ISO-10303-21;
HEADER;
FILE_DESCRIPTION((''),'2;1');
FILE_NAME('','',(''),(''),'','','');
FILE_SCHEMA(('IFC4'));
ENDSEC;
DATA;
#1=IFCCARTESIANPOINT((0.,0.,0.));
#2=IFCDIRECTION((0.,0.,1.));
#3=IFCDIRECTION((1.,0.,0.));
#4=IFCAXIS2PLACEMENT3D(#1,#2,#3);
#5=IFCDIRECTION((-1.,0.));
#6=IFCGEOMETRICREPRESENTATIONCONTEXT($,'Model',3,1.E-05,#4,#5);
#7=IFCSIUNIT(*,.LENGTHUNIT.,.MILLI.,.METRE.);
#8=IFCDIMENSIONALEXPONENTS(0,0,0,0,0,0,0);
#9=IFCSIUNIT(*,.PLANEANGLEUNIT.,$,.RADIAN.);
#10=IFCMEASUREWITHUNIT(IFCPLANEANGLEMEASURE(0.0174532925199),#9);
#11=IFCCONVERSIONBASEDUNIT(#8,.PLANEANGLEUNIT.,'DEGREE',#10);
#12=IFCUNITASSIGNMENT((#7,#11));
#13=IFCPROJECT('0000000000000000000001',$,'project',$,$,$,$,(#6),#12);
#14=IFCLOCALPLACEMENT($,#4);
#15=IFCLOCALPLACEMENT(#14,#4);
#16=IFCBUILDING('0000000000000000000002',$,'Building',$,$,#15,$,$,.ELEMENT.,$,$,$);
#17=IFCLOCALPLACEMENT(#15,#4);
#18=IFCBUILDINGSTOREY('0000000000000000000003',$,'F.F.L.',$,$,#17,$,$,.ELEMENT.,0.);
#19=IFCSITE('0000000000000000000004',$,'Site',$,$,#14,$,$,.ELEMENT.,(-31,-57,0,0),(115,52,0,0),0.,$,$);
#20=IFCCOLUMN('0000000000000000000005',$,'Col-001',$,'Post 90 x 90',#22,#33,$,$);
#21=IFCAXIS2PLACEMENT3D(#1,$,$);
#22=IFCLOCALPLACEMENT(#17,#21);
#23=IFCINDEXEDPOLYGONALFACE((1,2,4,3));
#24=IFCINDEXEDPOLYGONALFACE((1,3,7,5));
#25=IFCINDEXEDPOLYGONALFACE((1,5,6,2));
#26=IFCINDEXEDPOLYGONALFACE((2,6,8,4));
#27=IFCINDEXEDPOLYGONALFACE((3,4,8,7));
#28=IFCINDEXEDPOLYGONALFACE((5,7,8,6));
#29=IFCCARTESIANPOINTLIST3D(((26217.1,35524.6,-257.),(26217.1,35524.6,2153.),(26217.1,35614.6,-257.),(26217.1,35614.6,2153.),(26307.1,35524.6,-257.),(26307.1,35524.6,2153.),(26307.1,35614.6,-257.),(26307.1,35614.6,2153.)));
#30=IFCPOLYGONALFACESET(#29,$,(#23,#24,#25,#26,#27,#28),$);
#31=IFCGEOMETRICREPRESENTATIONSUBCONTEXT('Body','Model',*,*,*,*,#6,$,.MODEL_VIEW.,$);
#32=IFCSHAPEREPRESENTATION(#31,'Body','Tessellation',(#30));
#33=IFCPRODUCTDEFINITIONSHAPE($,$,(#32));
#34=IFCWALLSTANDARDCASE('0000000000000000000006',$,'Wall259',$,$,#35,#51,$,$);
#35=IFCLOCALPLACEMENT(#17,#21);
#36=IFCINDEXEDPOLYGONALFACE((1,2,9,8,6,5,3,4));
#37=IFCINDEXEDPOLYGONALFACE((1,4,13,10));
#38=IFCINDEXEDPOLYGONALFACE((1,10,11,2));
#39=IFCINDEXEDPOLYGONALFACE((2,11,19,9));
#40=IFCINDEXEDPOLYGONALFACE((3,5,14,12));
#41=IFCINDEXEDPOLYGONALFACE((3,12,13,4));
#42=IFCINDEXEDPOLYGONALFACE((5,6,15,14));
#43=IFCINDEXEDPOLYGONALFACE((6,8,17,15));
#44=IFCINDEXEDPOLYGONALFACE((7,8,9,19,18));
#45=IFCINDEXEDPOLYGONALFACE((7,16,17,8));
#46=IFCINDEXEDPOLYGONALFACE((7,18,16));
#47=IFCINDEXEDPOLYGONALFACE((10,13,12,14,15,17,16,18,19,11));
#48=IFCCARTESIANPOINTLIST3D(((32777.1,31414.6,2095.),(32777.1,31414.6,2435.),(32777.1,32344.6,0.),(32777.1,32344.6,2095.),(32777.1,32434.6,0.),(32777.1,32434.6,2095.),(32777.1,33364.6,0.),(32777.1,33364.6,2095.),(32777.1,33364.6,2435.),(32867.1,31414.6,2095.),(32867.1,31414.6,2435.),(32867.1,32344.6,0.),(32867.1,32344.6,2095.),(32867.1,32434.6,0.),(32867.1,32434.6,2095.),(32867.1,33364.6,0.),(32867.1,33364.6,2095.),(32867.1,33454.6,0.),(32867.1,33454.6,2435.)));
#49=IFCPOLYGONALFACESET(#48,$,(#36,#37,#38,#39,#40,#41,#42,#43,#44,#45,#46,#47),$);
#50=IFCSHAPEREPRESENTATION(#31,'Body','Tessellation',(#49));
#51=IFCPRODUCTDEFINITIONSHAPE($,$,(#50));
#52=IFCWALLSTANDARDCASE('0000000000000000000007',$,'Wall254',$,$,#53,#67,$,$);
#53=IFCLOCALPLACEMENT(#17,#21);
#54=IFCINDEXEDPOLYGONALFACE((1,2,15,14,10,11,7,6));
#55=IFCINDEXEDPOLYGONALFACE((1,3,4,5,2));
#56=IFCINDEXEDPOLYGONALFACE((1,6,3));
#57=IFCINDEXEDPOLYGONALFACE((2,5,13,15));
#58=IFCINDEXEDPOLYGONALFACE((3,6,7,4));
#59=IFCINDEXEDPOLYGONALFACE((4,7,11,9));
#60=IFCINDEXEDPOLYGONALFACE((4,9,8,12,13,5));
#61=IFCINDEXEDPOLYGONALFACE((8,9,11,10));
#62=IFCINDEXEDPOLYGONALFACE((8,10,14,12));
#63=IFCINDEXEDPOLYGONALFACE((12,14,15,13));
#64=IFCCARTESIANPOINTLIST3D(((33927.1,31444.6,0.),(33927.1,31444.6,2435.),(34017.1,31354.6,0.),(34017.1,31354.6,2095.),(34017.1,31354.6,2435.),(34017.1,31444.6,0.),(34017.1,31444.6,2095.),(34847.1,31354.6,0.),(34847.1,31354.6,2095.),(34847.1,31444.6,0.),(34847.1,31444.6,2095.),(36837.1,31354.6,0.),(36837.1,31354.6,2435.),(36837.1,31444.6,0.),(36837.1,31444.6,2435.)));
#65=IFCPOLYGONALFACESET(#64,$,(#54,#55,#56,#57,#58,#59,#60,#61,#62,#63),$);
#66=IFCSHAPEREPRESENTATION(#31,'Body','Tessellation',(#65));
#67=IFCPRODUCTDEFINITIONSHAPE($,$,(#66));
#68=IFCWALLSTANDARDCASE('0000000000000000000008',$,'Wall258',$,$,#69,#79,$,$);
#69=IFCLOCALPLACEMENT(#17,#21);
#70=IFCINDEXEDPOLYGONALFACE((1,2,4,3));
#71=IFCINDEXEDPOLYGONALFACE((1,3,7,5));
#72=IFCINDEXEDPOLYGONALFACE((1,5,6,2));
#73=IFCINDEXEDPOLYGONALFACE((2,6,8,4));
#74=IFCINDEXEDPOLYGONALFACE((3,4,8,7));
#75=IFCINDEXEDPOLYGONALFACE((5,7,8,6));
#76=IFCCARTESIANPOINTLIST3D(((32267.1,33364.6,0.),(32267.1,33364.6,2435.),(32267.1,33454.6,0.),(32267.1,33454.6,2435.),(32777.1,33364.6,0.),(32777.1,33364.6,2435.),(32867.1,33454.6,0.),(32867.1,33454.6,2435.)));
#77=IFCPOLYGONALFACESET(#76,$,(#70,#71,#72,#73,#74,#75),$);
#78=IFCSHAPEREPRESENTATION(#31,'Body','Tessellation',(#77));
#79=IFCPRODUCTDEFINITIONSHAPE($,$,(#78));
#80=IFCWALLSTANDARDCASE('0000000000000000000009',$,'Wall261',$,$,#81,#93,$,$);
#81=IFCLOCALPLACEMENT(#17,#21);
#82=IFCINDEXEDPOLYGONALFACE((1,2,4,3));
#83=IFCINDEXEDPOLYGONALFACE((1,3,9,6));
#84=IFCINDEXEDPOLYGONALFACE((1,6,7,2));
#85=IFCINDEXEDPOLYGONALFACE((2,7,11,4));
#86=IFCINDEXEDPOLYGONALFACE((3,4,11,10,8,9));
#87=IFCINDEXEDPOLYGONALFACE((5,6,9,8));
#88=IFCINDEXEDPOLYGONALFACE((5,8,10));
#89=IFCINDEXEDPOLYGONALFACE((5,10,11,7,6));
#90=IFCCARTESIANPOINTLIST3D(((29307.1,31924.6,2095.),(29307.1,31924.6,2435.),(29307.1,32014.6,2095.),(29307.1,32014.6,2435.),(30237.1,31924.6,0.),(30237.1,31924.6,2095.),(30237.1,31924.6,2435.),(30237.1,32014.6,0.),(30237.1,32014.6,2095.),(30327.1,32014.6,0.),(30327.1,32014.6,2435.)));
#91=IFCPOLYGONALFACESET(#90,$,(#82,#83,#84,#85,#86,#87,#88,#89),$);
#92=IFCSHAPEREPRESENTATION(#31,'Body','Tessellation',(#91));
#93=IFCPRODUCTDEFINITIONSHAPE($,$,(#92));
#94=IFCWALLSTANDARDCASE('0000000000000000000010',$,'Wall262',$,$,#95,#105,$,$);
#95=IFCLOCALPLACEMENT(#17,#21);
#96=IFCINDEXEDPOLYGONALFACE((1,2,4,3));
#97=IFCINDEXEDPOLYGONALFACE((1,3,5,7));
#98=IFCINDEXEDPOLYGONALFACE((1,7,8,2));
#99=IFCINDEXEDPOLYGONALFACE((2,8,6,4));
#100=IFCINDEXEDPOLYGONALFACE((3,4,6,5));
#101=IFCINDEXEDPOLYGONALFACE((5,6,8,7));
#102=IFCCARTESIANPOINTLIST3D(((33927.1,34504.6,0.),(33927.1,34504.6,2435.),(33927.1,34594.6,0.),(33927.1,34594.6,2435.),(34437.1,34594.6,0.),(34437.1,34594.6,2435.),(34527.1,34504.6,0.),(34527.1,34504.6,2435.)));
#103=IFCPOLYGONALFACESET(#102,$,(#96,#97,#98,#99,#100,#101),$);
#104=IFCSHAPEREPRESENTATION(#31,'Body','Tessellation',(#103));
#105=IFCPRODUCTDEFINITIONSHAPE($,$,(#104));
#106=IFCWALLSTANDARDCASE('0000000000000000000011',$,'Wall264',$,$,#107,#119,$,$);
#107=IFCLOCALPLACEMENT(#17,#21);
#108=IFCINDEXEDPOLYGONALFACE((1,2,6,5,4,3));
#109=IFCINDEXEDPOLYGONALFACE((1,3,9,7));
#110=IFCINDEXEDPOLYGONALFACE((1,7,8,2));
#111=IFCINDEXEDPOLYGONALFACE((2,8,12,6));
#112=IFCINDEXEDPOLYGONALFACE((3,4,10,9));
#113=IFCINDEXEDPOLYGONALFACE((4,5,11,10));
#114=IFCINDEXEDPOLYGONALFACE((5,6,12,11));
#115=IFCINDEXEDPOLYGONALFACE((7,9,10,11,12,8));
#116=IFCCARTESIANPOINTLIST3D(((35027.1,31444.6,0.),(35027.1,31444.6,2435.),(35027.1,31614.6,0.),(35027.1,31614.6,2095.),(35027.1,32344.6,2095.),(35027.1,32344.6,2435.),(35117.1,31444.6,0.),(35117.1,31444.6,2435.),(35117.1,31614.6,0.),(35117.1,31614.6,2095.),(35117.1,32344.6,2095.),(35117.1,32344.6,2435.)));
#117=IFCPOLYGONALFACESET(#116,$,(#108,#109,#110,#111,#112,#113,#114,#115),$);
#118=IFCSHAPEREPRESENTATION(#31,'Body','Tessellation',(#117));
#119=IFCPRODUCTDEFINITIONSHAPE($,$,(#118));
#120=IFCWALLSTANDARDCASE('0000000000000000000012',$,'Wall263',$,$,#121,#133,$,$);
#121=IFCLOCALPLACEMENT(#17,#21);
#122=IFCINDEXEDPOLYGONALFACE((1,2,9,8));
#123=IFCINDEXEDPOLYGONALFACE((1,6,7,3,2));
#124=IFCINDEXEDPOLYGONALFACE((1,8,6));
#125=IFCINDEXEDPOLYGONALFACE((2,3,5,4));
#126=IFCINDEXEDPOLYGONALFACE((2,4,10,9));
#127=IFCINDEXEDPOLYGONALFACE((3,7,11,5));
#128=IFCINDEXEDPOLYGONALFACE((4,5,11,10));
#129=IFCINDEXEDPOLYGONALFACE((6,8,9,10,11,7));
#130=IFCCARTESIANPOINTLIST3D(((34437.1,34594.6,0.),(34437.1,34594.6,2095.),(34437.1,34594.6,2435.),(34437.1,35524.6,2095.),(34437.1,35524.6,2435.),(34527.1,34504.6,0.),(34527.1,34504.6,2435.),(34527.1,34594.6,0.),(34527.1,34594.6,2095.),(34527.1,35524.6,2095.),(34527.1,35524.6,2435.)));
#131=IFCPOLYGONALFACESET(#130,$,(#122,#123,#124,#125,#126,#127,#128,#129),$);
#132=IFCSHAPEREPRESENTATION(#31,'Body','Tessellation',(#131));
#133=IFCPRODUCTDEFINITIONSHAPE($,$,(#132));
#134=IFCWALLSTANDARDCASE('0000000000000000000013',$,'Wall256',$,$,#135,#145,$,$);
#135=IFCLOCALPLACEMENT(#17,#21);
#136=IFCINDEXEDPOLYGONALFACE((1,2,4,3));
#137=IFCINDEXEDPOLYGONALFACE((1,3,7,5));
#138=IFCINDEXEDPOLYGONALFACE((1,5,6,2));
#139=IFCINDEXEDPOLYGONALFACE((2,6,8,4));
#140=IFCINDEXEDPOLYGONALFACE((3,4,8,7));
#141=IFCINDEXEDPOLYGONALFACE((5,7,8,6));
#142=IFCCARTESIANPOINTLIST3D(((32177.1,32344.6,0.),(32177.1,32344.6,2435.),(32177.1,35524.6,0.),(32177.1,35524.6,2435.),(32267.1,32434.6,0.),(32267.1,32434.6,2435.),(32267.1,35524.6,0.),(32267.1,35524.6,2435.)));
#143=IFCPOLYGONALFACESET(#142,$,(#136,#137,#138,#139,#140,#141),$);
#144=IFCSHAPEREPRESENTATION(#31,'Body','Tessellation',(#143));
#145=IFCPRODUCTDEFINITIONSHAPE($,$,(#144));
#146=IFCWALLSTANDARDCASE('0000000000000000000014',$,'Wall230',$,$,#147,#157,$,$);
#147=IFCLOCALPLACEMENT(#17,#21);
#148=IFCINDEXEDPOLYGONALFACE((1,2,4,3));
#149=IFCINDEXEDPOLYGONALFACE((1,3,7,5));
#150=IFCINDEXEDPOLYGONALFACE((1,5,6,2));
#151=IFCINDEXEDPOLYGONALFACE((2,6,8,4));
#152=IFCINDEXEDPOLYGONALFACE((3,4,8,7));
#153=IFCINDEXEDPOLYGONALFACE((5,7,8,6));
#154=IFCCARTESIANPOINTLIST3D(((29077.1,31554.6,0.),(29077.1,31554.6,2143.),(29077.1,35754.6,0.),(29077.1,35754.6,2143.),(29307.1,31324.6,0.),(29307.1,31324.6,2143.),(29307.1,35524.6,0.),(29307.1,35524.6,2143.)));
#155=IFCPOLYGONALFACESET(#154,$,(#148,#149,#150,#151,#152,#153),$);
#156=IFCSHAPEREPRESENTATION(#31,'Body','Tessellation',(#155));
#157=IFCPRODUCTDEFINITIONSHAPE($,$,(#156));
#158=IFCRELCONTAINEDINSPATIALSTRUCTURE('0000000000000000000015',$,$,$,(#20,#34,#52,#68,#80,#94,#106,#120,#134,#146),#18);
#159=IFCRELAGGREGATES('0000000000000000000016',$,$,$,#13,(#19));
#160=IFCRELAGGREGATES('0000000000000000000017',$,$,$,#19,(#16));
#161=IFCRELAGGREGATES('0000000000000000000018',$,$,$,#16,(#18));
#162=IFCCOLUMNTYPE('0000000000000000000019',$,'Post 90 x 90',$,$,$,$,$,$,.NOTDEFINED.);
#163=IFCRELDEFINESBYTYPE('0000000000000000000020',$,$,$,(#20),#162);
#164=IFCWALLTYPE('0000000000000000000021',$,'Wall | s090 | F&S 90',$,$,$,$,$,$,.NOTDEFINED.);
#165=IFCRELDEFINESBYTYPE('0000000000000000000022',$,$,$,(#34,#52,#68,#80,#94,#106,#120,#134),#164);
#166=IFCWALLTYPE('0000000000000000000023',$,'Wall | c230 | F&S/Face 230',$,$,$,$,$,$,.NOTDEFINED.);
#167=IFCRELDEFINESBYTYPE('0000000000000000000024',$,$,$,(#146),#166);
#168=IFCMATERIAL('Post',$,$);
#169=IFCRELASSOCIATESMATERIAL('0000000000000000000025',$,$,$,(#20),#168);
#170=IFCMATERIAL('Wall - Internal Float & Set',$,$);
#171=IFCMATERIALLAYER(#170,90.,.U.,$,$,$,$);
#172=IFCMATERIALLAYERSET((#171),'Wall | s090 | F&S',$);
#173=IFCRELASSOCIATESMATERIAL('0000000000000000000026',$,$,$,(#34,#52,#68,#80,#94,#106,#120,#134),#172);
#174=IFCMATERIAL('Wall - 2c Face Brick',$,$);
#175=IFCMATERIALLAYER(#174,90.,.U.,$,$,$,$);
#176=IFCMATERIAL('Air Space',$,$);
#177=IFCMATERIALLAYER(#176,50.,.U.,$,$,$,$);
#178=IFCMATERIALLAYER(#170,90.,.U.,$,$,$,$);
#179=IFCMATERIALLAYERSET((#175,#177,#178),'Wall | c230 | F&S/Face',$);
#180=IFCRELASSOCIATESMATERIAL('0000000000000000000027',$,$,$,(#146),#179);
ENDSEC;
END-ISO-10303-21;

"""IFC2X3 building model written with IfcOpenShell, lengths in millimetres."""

from ifc_helpers import new_model, entity, si_unit, converted_unit, direction, frame, origin_with_axes, origin_2d_with_axis, place, context, subcontext, project, spatial, polyline, rectangle, outline, extrude, material, layer, layer_set, layer_usage, type_object, element, save


model = new_model("IFC2X3")

# Units and contexts
model_context = context("Model", 3, precision=1e-05, world=origin_with_axes(), true_north=direction((-1.0, 0.0)))
body_context = subcontext(model_context, "Body", "Model", "MODEL_VIEW")
ifc_project = project(units=[si_unit("LENGTHUNIT", "METRE", prefix="MILLI"), converted_unit("PLANEANGLEUNIT", "DEGREE", entity("IfcPlaneAngleMeasure", 0.0174532925199), si_unit("PLANEANGLEUNIT", "RADIAN"), dimensions=[0, 0, 0, 0, 0, 0, 0])], contexts=[model_context])

# Site, building, storey
site_placement = place(None, origin_with_axes())
site = spatial("IfcSite", under=ifc_project, at=site_placement, Name="Site", CompositionType="ELEMENT", RefLatitude=(-31, -57, 0, 0), RefLongitude=(115, 52, 0, 0), RefElevation=0.0)
building_placement = place(site_placement, origin_with_axes())
building = spatial("IfcBuilding", under=site, at=building_placement, Name="Building", CompositionType="ELEMENT")
storey_placement = place(building_placement, origin_with_axes())
storey = spatial("IfcBuildingStorey", under=building, at=storey_placement, Name="F.F.L.", CompositionType="ELEMENT", Elevation=0.0)

# Column
ifc_material_1 = material(Name="Post")
column_type = type_object("IfcColumnType", Name="Post 90 x 90", PredefinedType="NOTDEFINED")
column_placement = place(storey_placement, frame((26262.1, 35569.6, -257.0), z_axis=(0.0, 0.0, 1.0), x_axis=(1.0, 0.0, 0.0)))
element("IfcColumn", 1, at=column_placement, inside=storey, type_object=column_type, material=ifc_material_1, Name="Col-001", ObjectType="Post 90 x 90", context=body_context, shape_type="SweptSolid", body=[
    extrude(rectangle(XDim=90.0, YDim=90.0, at=origin_2d_with_axis()), origin_with_axes(), (0.0, 0.0, 1.0), 2410.0),
])

# Shared definitions
ifc_material_2 = material(Name="Wall - Internal Float & Set")
ifc_layer_1 = layer(ifc_material_2, 90.0, ventilated="UNKNOWN")
ifc_layer_set_1 = layer_set([ifc_layer_1], Name="Wall | s090 | F&S")
wall_type_1 = type_object("IfcWallType", Name="Wall | s090 | F&S 90", PredefinedType="NOTDEFINED")

# Wall, openings
ifc_layer_usage_1 = layer_usage(ifc_layer_set_1, "AXIS2", "POSITIVE", -90.0)
wall_1_placement = place(storey_placement, frame((32867.1, 33454.6, 0.0), z_axis=(0.0, 0.0, 1.0), x_axis=(0.0, -1.0, 0.0)))
wall_1 = element("IfcWallStandardCase", 2, at=wall_1_placement, inside=storey, type_object=wall_type_1, material=ifc_layer_usage_1, Name="Wall259", context=body_context, shape_type="SweptSolid", body=[
    extrude(outline(polyline([(90.0, -90.0), (2040.0, -90.0), (2040.0, 0.0), (0.0, 0.0), (90.0, -90.0)])), origin_with_axes(), (0.0, 0.0, 1.0), 2435.0),
])
opening_1_placement = place(wall_1_placement, frame((555.0, 0.0, 0.0), z_axis=(0.0, 0.0, 1.0), x_axis=(1.0, 0.0, 0.0)))
element("IfcOpeningElement", 3, at=opening_1_placement, cuts=wall_1, context=body_context, shape_type="SweptSolid", body=[
    extrude(rectangle(XDim=930.0, YDim=2095.0, at=origin_2d_with_axis()), frame((0.0, -90.0, 1047.5), z_axis=(0.0, 1.0, 0.0), x_axis=(1.0, 0.0, 0.0)), (0.0, 0.0, 1.0), 180.0),
])
opening_2_placement = place(wall_1_placement, frame((1575.0, 0.0, 0.0), z_axis=(0.0, 0.0, 1.0), x_axis=(1.0, 0.0, 0.0)))
element("IfcOpeningElement", 4, at=opening_2_placement, cuts=wall_1, context=body_context, shape_type="SweptSolid", body=[
    extrude(rectangle(XDim=930.0, YDim=2095.0, at=origin_2d_with_axis()), frame((0.0, 90.0, 1047.5), z_axis=(0.0, 1.0, 0.0), x_axis=(1.0, 0.0, 0.0)), (0.0, 0.0, -1.0), 180.0),
])

# Wall, opening
ifc_layer_usage_2 = layer_usage(ifc_layer_set_1, "AXIS2", "POSITIVE", -90.0)
wall_2_placement = place(storey_placement, frame((33927.1, 31444.6, 0.0), z_axis=(0.0, 0.0, 1.0), x_axis=(1.0, 0.0, 0.0)))
wall_2 = element("IfcWallStandardCase", 5, at=wall_2_placement, inside=storey, type_object=wall_type_1, material=ifc_layer_usage_2, Name="Wall254", context=body_context, shape_type="SweptSolid", body=[
    extrude(outline(polyline([(90.0, -90.0), (2910.0, -90.0), (2910.0, 0.0), (0.0, 0.0), (90.0, -90.0)])), origin_with_axes(), (0.0, 0.0, 1.0), 2435.0),
])
opening_3_placement = place(wall_2_placement, frame((505.0, 0.0, 0.0), z_axis=(0.0, 0.0, 1.0), x_axis=(1.0, 0.0, 0.0)))
element("IfcOpeningElement", 6, at=opening_3_placement, cuts=wall_2, context=body_context, shape_type="SweptSolid", body=[
    extrude(rectangle(XDim=830.0, YDim=2095.0, at=origin_2d_with_axis()), frame((0.0, 90.0, 1047.5), z_axis=(0.0, -1.0, 0.0), x_axis=(-1.0, 0.0, 0.0)), (0.0, 0.0, 1.0), 180.0),
])

# Wall
ifc_layer_usage_3 = layer_usage(ifc_layer_set_1, "AXIS2", "POSITIVE", -90.0)
wall_3_placement = place(storey_placement, frame((32177.1, 33454.6, 0.0), z_axis=(0.0, 0.0, 1.0), x_axis=(1.0, 0.0, 0.0)))
element("IfcWallStandardCase", 7, at=wall_3_placement, inside=storey, type_object=wall_type_1, material=ifc_layer_usage_3, Name="Wall258", context=body_context, shape_type="SweptSolid", body=[
    extrude(outline(polyline([(90.0, -90.0), (600.0, -90.0), (690.0, 0.0), (90.0, 0.0), (90.0, -90.0)])), origin_with_axes(), (0.0, 0.0, 1.0), 2435.0),
])

# Wall, opening
ifc_layer_usage_4 = layer_usage(ifc_layer_set_1, "AXIS2", "NEGATIVE", 90.0)
wall_4_placement = place(storey_placement, frame((30327.1, 32014.6, 0.0), z_axis=(0.0, 0.0, 1.0), x_axis=(-1.0, 0.0, 0.0)))
wall_4 = element("IfcWallStandardCase", 8, at=wall_4_placement, inside=storey, type_object=wall_type_1, material=ifc_layer_usage_4, Name="Wall261", context=body_context, shape_type="SweptSolid", body=[
    extrude(outline(polyline([(0.0, 0.0), (1020.0, 0.0), (1020.0, 90.0), (90.0, 90.0), (0.0, 0.0)])), origin_with_axes(), (0.0, 0.0, 1.0), 2435.0),
])
opening_4_placement = place(wall_4_placement, frame((555.0, 0.0, 0.0), z_axis=(0.0, 0.0, 1.0), x_axis=(1.0, 0.0, 0.0)))
element("IfcOpeningElement", 9, at=opening_4_placement, cuts=wall_4, context=body_context, shape_type="SweptSolid", body=[
    extrude(rectangle(XDim=930.0, YDim=2095.0, at=origin_2d_with_axis()), frame((0.0, 90.0, 1047.5), z_axis=(0.0, 1.0, 0.0), x_axis=(1.0, 0.0, 0.0)), (0.0, 0.0, -1.0), 180.0),
])

# Wall
ifc_layer_usage_5 = layer_usage(ifc_layer_set_1, "AXIS2", "NEGATIVE", 90.0)
wall_5_placement = place(storey_placement, frame((33927.1, 34504.6, 0.0), z_axis=(0.0, 0.0, 1.0), x_axis=(1.0, 0.0, 0.0)))
element("IfcWallStandardCase", 10, at=wall_5_placement, inside=storey, type_object=wall_type_1, material=ifc_layer_usage_5, Name="Wall262", context=body_context, shape_type="SweptSolid", body=[
    extrude(outline(polyline([(0.0, 0.0), (600.0, 0.0), (510.0, 90.0), (0.0, 90.0), (0.0, 0.0)])), origin_with_axes(), (0.0, 0.0, 1.0), 2435.0),
])

# Walls, openings
ifc_layer_usage_6 = layer_usage(ifc_layer_set_1, "AXIS2", "POSITIVE", -90.0)
wall_6_placement = place(storey_placement, frame((35027.1, 31444.6, 0.0), z_axis=(0.0, 0.0, 1.0), x_axis=(0.0, 1.0, 0.0)))
wall_6 = element("IfcWallStandardCase", 11, at=wall_6_placement, inside=storey, type_object=wall_type_1, material=ifc_layer_usage_6, Name="Wall264", context=body_context, shape_type="SweptSolid", body=[
    extrude(outline(polyline([(0.0, -90.0), (900.0, -90.0), (900.0, 0.0), (0.0, 0.0), (0.0, -90.0)])), origin_with_axes(), (0.0, 0.0, 1.0), 2435.0),
])
opening_5_placement = place(wall_6_placement, frame((535.0, 0.0, 0.0), z_axis=(0.0, 0.0, 1.0), x_axis=(1.0, 0.0, 0.0)))
element("IfcOpeningElement", 12, at=opening_5_placement, cuts=wall_6, context=body_context, shape_type="SweptSolid", body=[
    extrude(rectangle(XDim=730.0, YDim=2095.0, at=origin_2d_with_axis()), frame((0.0, 90.0, 1047.5), z_axis=(0.0, 1.0, 0.0), x_axis=(1.0, 0.0, 0.0)), (0.0, 0.0, -1.0), 180.0),
])
ifc_layer_usage_7 = layer_usage(ifc_layer_set_1, "AXIS2", "NEGATIVE", 90.0)
wall_7_placement = place(storey_placement, frame((34527.1, 34504.6, 0.0), z_axis=(0.0, 0.0, 1.0), x_axis=(0.0, 1.0, 0.0)))
wall_7 = element("IfcWallStandardCase", 13, at=wall_7_placement, inside=storey, type_object=wall_type_1, material=ifc_layer_usage_7, Name="Wall263", context=body_context, shape_type="SweptSolid", body=[
    extrude(outline(polyline([(0.0, 0.0), (1020.0, 0.0), (1020.0, 90.0), (90.0, 90.0), (0.0, 0.0)])), origin_with_axes(), (0.0, 0.0, 1.0), 2435.0),
])
opening_6_placement = place(wall_7_placement, frame((555.0, 0.0, 0.0), z_axis=(0.0, 0.0, 1.0), x_axis=(1.0, 0.0, 0.0)))
element("IfcOpeningElement", 14, at=opening_6_placement, cuts=wall_7, context=body_context, shape_type="SweptSolid", body=[
    extrude(rectangle(XDim=930.0, YDim=2095.0, at=origin_2d_with_axis()), frame((0.0, 90.0, 1047.5), z_axis=(0.0, 1.0, 0.0), x_axis=(1.0, 0.0, 0.0)), (0.0, 0.0, -1.0), 180.0),
])

# Wall
ifc_layer_usage_8 = layer_usage(ifc_layer_set_1, "AXIS2", "POSITIVE", -90.0)
wall_8_placement = place(storey_placement, frame((32177.1, 32344.6, 0.0), z_axis=(0.0, 0.0, 1.0), x_axis=(0.0, 1.0, 0.0)))
element("IfcWallStandardCase", 15, at=wall_8_placement, inside=storey, type_object=wall_type_1, material=ifc_layer_usage_8, Name="Wall256", context=body_context, shape_type="SweptSolid", body=[
    extrude(outline(polyline([(90.0, -90.0), (3180.0, -90.0), (3180.0, 0.0), (0.0, 0.0), (90.0, -90.0)])), origin_with_axes(), (0.0, 0.0, 1.0), 2435.0),
])

# Wall
ifc_material_3 = material(Name="Wall - 2c Face Brick")
ifc_layer_2 = layer(ifc_material_3, 90.0, ventilated="UNKNOWN")
ifc_material_4 = material(Name="Air Space")
ifc_layer_3 = layer(ifc_material_4, 50.0, ventilated="UNKNOWN")
ifc_layer_4 = layer(ifc_material_2, 90.0, ventilated="UNKNOWN")
ifc_layer_set_2 = layer_set([ifc_layer_2, ifc_layer_3, ifc_layer_4], Name="Wall | c230 | F&S/Face")
ifc_layer_usage_9 = layer_usage(ifc_layer_set_2, "AXIS2", "NEGATIVE", 0.0)
wall_type_2 = type_object("IfcWallType", Name="Wall | c230 | F&S/Face 230", PredefinedType="NOTDEFINED")
wall_9_placement = place(storey_placement, frame((29077.1, 31554.6, 0.0), z_axis=(0.0, 0.0, 1.0), x_axis=(0.0, 1.0, 0.0)))
element("IfcWallStandardCase", 16, at=wall_9_placement, inside=storey, type_object=wall_type_2, material=ifc_layer_usage_9, Name="Wall230", context=body_context, shape_type="SweptSolid", body=[
    extrude(outline(polyline([(-230.0, -230.0), (3970.0, -230.0), (4200.0, 0.0), (0.0, 0.0), (-230.0, -230.0)])), origin_with_axes(), (0.0, 0.0, 1.0), 2143.0),
])

save(model, "model.ifc")
